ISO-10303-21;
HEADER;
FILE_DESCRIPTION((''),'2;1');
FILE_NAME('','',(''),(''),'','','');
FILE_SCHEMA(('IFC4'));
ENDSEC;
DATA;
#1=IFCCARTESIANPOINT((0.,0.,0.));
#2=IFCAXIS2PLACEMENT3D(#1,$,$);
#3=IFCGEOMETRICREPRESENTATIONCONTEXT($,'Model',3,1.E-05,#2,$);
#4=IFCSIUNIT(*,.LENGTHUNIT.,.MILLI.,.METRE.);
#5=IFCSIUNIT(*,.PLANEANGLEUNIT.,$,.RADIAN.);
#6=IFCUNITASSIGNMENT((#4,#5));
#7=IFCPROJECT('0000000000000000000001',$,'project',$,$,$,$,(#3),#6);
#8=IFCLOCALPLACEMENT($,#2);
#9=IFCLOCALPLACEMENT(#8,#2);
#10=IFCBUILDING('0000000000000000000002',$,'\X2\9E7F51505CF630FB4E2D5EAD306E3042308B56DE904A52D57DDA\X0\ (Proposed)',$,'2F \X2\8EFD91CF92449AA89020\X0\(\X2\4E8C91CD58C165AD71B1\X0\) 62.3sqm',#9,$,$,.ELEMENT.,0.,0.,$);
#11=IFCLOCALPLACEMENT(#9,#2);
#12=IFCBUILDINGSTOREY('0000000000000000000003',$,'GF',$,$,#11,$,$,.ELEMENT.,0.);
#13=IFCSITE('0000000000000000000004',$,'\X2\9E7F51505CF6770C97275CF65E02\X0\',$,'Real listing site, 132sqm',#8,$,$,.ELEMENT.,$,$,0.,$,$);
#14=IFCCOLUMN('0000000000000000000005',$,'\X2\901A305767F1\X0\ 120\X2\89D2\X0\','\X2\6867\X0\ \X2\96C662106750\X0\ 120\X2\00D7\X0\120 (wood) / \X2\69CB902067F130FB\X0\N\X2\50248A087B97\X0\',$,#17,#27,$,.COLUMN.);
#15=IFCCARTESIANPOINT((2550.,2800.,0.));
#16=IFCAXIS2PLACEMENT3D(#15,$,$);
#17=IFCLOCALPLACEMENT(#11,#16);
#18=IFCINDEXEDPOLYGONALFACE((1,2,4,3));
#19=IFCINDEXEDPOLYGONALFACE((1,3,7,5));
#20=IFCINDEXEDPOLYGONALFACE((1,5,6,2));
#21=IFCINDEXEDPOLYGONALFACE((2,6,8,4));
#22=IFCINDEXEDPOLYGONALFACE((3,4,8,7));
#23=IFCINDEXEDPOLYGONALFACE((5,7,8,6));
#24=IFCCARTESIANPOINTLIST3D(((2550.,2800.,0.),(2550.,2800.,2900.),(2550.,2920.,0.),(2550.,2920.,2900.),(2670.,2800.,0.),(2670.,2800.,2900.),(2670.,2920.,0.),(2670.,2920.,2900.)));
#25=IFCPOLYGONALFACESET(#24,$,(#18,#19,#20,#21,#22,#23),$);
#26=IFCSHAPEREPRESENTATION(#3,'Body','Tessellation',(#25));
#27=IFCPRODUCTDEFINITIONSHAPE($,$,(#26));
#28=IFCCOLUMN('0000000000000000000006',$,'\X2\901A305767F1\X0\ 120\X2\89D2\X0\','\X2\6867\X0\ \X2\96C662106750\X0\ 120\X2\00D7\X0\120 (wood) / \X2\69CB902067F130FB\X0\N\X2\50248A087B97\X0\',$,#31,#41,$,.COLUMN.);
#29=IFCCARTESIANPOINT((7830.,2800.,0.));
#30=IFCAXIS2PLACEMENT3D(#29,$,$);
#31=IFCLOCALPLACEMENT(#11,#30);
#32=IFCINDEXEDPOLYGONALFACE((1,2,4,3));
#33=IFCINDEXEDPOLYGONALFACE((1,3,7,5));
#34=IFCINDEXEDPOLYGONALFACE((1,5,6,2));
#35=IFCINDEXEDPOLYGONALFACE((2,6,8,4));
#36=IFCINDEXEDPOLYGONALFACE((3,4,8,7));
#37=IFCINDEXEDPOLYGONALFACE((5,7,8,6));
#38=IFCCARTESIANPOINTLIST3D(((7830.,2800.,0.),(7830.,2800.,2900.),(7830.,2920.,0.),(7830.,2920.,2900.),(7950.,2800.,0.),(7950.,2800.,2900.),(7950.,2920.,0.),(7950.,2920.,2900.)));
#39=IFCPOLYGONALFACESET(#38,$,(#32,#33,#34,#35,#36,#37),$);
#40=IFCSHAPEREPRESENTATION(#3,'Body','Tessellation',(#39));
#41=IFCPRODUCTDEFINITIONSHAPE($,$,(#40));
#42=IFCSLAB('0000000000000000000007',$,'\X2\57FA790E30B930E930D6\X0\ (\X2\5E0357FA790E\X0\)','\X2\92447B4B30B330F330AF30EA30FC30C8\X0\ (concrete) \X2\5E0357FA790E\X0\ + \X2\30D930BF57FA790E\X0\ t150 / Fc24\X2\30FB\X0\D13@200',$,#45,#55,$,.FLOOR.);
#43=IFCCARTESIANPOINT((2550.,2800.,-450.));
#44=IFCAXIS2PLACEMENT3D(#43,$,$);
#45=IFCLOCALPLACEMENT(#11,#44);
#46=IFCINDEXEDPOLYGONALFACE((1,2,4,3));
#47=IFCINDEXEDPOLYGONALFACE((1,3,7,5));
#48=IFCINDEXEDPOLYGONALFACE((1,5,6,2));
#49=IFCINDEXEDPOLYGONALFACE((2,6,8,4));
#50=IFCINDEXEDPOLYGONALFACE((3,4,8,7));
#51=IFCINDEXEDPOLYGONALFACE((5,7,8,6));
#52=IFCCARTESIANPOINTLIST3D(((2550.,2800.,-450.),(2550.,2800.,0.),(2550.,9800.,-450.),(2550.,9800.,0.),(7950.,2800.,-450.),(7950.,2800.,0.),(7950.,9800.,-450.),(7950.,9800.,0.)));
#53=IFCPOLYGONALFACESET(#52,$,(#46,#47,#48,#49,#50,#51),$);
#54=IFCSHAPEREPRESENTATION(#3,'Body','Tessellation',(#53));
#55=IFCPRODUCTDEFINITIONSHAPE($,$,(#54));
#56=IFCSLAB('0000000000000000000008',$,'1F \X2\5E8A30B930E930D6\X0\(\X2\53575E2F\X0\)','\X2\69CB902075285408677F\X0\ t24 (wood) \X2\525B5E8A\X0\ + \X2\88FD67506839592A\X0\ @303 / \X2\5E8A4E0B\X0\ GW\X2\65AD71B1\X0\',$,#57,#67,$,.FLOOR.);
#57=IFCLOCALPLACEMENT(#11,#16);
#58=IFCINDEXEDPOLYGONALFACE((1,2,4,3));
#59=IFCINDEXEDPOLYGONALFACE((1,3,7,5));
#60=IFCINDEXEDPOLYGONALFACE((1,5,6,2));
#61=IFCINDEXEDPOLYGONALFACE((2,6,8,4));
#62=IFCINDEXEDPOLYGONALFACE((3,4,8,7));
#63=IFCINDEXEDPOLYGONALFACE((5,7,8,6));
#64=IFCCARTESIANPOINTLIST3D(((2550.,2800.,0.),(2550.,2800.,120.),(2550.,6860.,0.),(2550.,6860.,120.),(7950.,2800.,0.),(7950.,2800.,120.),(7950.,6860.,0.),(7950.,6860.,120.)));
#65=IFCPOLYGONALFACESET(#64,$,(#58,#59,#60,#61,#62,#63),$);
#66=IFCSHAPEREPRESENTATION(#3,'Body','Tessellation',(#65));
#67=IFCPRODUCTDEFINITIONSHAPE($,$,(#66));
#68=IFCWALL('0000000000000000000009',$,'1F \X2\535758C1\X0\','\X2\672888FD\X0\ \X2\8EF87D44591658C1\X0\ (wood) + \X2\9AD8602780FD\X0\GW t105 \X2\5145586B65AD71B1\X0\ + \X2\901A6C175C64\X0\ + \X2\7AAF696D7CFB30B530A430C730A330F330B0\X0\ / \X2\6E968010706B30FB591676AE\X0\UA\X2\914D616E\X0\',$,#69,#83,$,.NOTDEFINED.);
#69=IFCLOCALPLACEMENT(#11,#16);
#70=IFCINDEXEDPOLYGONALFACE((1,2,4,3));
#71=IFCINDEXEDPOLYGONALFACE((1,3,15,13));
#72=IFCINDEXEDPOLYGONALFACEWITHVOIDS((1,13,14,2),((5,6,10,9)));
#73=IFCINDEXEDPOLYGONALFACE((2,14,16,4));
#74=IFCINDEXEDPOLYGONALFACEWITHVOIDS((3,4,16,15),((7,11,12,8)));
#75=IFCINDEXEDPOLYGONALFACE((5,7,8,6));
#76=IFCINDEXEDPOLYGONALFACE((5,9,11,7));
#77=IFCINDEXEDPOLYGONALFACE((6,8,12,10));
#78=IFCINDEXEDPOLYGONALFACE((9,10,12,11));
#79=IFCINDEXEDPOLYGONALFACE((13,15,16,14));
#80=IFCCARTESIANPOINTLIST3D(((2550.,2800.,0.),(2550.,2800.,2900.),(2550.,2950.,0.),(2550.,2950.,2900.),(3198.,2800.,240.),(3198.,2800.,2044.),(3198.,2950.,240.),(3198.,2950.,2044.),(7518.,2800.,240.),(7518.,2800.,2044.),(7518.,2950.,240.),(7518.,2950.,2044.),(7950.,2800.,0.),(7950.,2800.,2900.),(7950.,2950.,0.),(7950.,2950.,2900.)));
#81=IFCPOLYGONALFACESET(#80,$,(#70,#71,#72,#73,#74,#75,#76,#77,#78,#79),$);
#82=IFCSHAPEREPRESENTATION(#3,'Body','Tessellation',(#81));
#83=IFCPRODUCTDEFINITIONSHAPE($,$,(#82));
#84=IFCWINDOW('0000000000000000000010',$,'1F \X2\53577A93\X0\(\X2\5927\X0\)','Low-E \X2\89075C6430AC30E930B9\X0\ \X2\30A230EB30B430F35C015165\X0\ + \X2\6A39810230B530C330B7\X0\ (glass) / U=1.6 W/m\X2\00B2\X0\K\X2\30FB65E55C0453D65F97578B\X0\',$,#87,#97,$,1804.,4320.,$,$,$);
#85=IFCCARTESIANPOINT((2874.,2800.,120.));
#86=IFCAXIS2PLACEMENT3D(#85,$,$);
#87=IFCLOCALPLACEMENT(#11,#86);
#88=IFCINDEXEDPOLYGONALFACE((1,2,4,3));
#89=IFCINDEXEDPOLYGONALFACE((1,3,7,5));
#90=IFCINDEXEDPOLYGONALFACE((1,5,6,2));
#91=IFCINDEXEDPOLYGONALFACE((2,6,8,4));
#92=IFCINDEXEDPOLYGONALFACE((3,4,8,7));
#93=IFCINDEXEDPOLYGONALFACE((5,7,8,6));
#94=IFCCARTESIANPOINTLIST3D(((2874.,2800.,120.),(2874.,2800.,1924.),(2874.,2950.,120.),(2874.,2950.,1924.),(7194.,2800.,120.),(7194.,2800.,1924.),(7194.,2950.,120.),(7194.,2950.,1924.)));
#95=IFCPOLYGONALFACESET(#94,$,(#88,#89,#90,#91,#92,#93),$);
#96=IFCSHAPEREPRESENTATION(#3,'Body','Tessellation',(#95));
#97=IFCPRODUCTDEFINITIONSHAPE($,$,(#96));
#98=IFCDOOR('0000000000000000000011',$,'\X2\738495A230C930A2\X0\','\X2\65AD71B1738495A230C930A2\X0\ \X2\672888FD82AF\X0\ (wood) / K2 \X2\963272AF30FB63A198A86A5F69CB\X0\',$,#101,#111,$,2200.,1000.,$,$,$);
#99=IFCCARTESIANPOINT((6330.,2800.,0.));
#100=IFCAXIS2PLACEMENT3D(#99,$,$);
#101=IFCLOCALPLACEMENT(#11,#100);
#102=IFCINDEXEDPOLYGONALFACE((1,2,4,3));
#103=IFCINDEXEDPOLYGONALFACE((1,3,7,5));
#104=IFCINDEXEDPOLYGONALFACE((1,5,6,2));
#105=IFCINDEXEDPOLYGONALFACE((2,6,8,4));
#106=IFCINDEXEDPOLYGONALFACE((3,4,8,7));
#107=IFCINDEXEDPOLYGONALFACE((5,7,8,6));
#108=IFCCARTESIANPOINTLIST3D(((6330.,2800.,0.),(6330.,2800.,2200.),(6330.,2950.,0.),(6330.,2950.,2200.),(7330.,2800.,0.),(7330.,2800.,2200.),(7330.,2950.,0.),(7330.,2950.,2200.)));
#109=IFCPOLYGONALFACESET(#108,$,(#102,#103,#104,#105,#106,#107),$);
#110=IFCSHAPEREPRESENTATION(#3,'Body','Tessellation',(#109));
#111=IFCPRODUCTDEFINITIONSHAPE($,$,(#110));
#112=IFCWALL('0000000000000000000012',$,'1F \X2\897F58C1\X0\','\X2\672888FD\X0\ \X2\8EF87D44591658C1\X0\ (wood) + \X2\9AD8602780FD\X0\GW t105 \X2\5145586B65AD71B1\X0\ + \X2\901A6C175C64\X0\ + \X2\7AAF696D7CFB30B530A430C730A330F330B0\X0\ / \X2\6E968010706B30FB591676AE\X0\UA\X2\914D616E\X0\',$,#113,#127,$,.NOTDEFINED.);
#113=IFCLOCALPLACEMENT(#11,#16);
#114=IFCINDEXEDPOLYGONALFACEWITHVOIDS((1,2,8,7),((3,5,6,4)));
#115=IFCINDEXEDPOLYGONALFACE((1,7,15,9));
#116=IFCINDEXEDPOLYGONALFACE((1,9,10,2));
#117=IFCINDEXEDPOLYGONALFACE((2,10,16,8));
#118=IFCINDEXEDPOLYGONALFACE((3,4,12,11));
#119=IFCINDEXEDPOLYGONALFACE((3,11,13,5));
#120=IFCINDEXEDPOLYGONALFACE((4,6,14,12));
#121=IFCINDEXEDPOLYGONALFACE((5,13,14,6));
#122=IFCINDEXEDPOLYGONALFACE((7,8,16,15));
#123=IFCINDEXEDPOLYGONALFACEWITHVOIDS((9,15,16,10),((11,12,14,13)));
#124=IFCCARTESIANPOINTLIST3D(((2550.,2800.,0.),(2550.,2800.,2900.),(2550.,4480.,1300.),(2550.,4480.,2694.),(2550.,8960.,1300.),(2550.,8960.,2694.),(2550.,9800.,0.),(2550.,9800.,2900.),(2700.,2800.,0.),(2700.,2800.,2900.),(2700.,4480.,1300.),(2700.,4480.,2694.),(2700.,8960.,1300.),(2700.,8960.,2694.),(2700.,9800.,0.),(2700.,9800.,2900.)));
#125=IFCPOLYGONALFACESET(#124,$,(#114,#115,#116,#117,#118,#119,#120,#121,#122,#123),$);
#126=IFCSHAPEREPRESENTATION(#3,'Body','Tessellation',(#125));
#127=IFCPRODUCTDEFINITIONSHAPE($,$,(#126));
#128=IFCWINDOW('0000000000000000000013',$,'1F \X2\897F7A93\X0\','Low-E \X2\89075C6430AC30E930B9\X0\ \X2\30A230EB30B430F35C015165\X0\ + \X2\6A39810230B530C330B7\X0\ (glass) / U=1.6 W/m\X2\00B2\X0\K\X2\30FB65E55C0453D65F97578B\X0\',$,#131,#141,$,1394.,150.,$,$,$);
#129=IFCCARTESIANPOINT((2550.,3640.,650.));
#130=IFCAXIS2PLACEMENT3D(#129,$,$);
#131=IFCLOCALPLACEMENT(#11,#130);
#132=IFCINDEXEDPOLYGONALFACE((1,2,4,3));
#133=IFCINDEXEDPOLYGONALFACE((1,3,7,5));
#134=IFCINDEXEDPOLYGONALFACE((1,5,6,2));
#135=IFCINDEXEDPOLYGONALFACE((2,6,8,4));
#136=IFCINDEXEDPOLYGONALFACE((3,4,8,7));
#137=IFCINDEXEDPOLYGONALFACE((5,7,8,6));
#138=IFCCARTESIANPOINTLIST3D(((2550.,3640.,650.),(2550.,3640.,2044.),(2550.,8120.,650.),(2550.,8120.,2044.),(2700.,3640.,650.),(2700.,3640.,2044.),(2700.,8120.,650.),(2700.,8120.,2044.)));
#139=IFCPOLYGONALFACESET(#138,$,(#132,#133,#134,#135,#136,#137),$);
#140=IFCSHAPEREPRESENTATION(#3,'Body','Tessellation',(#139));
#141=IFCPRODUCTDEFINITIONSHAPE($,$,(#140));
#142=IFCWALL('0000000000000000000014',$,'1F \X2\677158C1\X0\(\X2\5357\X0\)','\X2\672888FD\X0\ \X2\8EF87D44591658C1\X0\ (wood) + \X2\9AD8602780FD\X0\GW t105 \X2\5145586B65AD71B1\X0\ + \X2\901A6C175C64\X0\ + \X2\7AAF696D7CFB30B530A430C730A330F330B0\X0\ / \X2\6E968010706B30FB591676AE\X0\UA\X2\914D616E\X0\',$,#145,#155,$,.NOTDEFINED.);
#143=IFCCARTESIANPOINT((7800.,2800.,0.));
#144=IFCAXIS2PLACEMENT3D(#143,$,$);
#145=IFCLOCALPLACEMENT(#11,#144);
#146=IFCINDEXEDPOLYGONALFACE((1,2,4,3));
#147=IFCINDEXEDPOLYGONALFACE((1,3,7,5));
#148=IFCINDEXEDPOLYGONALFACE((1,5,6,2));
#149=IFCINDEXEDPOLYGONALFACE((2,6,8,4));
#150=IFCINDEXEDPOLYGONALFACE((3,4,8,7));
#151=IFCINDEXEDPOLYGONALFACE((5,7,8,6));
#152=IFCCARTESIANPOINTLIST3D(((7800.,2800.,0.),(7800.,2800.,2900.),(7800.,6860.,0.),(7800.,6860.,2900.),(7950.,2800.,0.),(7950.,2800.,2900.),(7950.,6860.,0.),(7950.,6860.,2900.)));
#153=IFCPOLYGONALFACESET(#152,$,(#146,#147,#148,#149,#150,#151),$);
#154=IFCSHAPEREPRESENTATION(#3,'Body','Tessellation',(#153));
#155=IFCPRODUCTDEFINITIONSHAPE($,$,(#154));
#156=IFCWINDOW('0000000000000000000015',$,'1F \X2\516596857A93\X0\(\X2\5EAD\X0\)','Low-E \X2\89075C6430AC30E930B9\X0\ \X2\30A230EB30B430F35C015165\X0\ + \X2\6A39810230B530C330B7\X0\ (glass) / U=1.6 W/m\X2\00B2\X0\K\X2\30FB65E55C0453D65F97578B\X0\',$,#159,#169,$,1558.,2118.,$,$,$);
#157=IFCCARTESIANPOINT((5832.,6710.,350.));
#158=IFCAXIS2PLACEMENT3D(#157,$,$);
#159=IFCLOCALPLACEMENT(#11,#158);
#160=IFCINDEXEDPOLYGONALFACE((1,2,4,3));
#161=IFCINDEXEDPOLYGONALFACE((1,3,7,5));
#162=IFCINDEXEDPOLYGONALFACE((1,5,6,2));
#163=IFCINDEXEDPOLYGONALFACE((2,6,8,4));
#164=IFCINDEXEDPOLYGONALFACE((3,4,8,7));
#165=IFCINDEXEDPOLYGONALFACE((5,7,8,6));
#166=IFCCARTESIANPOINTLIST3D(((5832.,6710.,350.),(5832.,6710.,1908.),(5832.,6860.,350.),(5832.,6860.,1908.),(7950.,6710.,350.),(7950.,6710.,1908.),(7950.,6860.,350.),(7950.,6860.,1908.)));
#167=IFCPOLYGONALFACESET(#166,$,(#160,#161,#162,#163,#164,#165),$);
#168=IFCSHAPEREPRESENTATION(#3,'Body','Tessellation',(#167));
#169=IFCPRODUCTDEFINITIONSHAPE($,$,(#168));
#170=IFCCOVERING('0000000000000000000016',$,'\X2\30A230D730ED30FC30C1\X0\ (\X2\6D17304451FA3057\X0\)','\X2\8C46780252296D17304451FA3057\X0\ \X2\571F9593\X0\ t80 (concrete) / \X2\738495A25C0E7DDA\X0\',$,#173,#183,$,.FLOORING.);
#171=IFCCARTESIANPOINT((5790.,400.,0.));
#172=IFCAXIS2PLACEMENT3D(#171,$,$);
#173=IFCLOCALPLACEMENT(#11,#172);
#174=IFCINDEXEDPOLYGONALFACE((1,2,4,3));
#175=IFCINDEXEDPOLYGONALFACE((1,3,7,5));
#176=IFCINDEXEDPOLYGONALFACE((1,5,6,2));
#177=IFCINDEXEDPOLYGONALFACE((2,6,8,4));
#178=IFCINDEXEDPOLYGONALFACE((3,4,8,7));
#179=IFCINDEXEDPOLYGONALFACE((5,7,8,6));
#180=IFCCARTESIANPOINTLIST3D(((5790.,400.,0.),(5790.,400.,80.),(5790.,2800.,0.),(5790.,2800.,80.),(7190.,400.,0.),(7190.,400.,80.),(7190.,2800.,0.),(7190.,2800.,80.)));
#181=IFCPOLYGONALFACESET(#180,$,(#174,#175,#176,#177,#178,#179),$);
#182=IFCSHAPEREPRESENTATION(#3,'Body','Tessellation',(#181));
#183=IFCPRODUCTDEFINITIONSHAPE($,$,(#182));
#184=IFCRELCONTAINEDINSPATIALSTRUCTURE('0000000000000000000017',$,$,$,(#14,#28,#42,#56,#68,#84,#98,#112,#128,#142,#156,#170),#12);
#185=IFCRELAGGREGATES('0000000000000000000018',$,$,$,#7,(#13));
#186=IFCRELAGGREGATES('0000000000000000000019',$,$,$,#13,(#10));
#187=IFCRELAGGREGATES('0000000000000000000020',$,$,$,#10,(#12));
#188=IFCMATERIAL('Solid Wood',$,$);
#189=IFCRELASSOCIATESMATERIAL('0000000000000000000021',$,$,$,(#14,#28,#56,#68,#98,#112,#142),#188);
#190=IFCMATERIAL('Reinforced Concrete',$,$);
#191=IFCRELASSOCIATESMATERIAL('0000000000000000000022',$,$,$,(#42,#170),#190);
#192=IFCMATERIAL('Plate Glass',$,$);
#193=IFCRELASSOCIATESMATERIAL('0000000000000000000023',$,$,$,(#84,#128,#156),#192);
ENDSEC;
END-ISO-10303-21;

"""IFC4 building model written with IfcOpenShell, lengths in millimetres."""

from ifc_helpers import new_model, si_unit, frame, frame_2d, origin, place, context, project, spatial, rectangle, extrude, material, element, fill, save


model = new_model("IFC4")

# Units and contexts
model_context = context("Model", 3, precision=1e-05, world=origin())
ifc_project = project(units=[si_unit("LENGTHUNIT", "METRE", prefix="MILLI"), si_unit("PLANEANGLEUNIT", "RADIAN")], contexts=[model_context])

# Site, building, storey
site_placement = place(None, origin())
site = spatial("IfcSite", under=ifc_project, at=site_placement, Name="鹿児島県霧島市", ObjectType="Real listing site, 132sqm", CompositionType="ELEMENT", RefElevation=0.0)
building_placement = place(site_placement, origin())
building = spatial("IfcBuilding", under=site, at=building_placement, Name="鹿児島・中庭のある回遊動線 (Proposed)", ObjectType="2F 軽量鉄骨造(二重壁断熱) 62.3sqm", CompositionType="ELEMENT", ElevationOfRefHeight=0.0, ElevationOfTerrain=0.0)
storey_placement = place(building_placement, origin())
storey = spatial("IfcBuildingStorey", under=building, at=storey_placement, Name="GF", CompositionType="ELEMENT", Elevation=0.0)

# Columns
ifc_material_1 = material(Name="Solid Wood")
column_1_placement = place(storey_placement, frame((2550.0, 2800.0, 0.0)))
element("IfcColumn", 1, at=column_1_placement, inside=storey, material=ifc_material_1, Name="通し柱 120角", Description="桧 集成材 120×120 (wood) / 構造柱・N値計算", PredefinedType="COLUMN", context=model_context, shape_type="SweptSolid", body=[
    extrude(rectangle(XDim=120.0, YDim=120.0, at=frame_2d((60.0, 60.0))), frame((2550.0, 2800.0, 0.0)), (0.0, 0.0, 1.0), 2900.0),
])
column_2_placement = place(storey_placement, frame((7830.0, 2800.0, 0.0)))
element("IfcColumn", 2, at=column_2_placement, inside=storey, material=ifc_material_1, Name="通し柱 120角", Description="桧 集成材 120×120 (wood) / 構造柱・N値計算", PredefinedType="COLUMN", context=model_context, shape_type="SweptSolid", body=[
    extrude(rectangle(XDim=120.0, YDim=120.0, at=frame_2d((60.0, 60.0))), frame((7830.0, 2800.0, 0.0)), (0.0, 0.0, 1.0), 2900.0),
])

# Slabs
ifc_material_2 = material(Name="Reinforced Concrete")
slab_1_placement = place(storey_placement, frame((2550.0, 2800.0, -450.0)))
element("IfcSlab", 3, at=slab_1_placement, inside=storey, material=ifc_material_2, Name="基礎スラブ (布基礎)", Description="鉄筋コンクリート (concrete) 布基礎 + ベタ基礎 t150 / Fc24・D13@200", PredefinedType="FLOOR", context=model_context, shape_type="SweptSolid", body=[
    extrude(rectangle(XDim=5400.0, YDim=7000.0, at=frame_2d((2700.0, 3500.0))), frame((2550.0, 2800.0, -450.0)), (0.0, 0.0, 1.0), 450.0),
])
slab_2_placement = place(storey_placement, frame((2550.0, 2800.0, 0.0)))
element("IfcSlab", 4, at=slab_2_placement, inside=storey, material=ifc_material_1, Name="1F 床スラブ(南帯)", Description="構造用合板 t24 (wood) 剛床 + 製材根太 @303 / 床下 GW断熱", PredefinedType="FLOOR", context=model_context, shape_type="SweptSolid", body=[
    extrude(rectangle(XDim=5400.0, YDim=4060.0, at=frame_2d((2700.0, 2030.0))), frame((2550.0, 2800.0, 0.0)), (0.0, 0.0, 1.0), 120.0),
])

# Wall, openings, window, door
wall_1_placement = place(storey_placement, frame((2550.0, 2800.0, 0.0)))
wall_1 = element("IfcWall", 5, at=wall_1_placement, inside=storey, material=ifc_material_1, Name="1F 南壁", Description="木製 軸組外壁 (wood) + 高性能GW t105 充填断熱 + 通気層 + 窯業系サイディング / 準耐火・外皮UA配慮", PredefinedType="NOTDEFINED", context=model_context, shape_type="SweptSolid", body=[
    extrude(rectangle(XDim=5400.0, YDim=150.0, at=frame_2d((2700.0, 75.0))), frame((2550.0, 2800.0, 0.0)), (0.0, 0.0, 1.0), 2900.0),
])
opening_1_placement = place(storey_placement, frame((2874.0, 2800.0, 120.0)))
opening_1 = element("IfcOpeningElement", 6, at=opening_1_placement, cuts=wall_1, PredefinedType="NOTDEFINED", context=model_context, shape_type="SweptSolid", body=[
    extrude(rectangle(XDim=4320.0, YDim=150.0, at=frame_2d((2160.0, 75.0))), frame((2874.0, 2800.0, 120.0)), (0.0, 0.0, 1.0), 1804.0),
])
opening_2_placement = place(storey_placement, frame((6330.0, 2800.0, 0.0)))
opening_2 = element("IfcOpeningElement", 7, at=opening_2_placement, cuts=wall_1, PredefinedType="NOTDEFINED", context=model_context, shape_type="SweptSolid", body=[
    extrude(rectangle(XDim=1000.0, YDim=150.0, at=frame_2d((500.0, 75.0))), frame((6330.0, 2800.0, 0.0)), (0.0, 0.0, 1.0), 2200.0),
])
ifc_material_3 = material(Name="Plate Glass")
window_1_placement = place(storey_placement, frame((2874.0, 2800.0, 120.0)))
window_1 = element("IfcWindow", 8, at=window_1_placement, inside=storey, material=ifc_material_3, Name="1F 南窓(大)", Description="Low-E 複層ガラス アルゴン封入 + 樹脂サッシ (glass) / U=1.6 W/m²K・日射取得型", OverallHeight=1804.0, OverallWidth=4320.0, context=model_context, shape_type="SweptSolid", body=[
    extrude(rectangle(XDim=4320.0, YDim=150.0, at=frame_2d((2160.0, 75.0))), frame((2874.0, 2800.0, 120.0)), (0.0, 0.0, 1.0), 1804.0),
])
fill(opening_1, window_1)
door_1_placement = place(storey_placement, frame((6330.0, 2800.0, 0.0)))
door_1 = element("IfcDoor", 9, at=door_1_placement, inside=storey, material=ifc_material_1, Name="玄関ドア", Description="断熱玄関ドア 木製芯 (wood) / K2 防犯・採風機構", OverallHeight=2200.0, OverallWidth=1000.0, context=model_context, shape_type="SweptSolid", body=[
    extrude(rectangle(XDim=1000.0, YDim=150.0, at=frame_2d((500.0, 75.0))), frame((6330.0, 2800.0, 0.0)), (0.0, 0.0, 1.0), 2200.0),
])
fill(opening_2, door_1)

# Walls, openings, windows
wall_2_placement = place(storey_placement, frame((2550.0, 2800.0, 0.0)))
wall_2 = element("IfcWall", 10, at=wall_2_placement, inside=storey, material=ifc_material_1, Name="1F 西壁", Description="木製 軸組外壁 (wood) + 高性能GW t105 充填断熱 + 通気層 + 窯業系サイディング / 準耐火・外皮UA配慮", PredefinedType="NOTDEFINED", context=model_context, shape_type="SweptSolid", body=[
    extrude(rectangle(XDim=150.0, YDim=7000.0, at=frame_2d((75.0, 3500.0))), frame((2550.0, 2800.0, 0.0)), (0.0, 0.0, 1.0), 2900.0),
])
opening_3_placement = place(storey_placement, frame((2550.0, 3640.0, 650.0)))
opening_3 = element("IfcOpeningElement", 11, at=opening_3_placement, cuts=wall_2, PredefinedType="NOTDEFINED", context=model_context, shape_type="SweptSolid", body=[
    extrude(rectangle(XDim=150.0, YDim=4480.0, at=frame_2d((75.0, 2240.0))), frame((2550.0, 3640.0, 650.0)), (0.0, 0.0, 1.0), 1394.0),
])
window_2_placement = place(storey_placement, frame((2550.0, 3640.0, 650.0)))
window_2 = element("IfcWindow", 12, at=window_2_placement, inside=storey, material=ifc_material_3, Name="1F 西窓", Description="Low-E 複層ガラス アルゴン封入 + 樹脂サッシ (glass) / U=1.6 W/m²K・日射取得型", OverallHeight=1394.0, OverallWidth=150.0, context=model_context, shape_type="SweptSolid", body=[
    extrude(rectangle(XDim=150.0, YDim=4480.0, at=frame_2d((75.0, 2240.0))), frame((2550.0, 3640.0, 650.0)), (0.0, 0.0, 1.0), 1394.0),
])
fill(opening_3, window_2)
wall_3_placement = place(storey_placement, frame((7800.0, 2800.0, 0.0)))
wall_3 = element("IfcWall", 13, at=wall_3_placement, inside=storey, material=ifc_material_1, Name="1F 東壁(南)", Description="木製 軸組外壁 (wood) + 高性能GW t105 充填断熱 + 通気層 + 窯業系サイディング / 準耐火・外皮UA配慮", PredefinedType="NOTDEFINED", context=model_context, shape_type="SweptSolid", body=[
    extrude(rectangle(XDim=150.0, YDim=4060.0, at=frame_2d((75.0, 2030.0))), frame((7800.0, 2800.0, 0.0)), (0.0, 0.0, 1.0), 2900.0),
])
opening_4_placement = place(storey_placement, frame((5832.0, 6710.0, 350.0)))
opening_4 = element("IfcOpeningElement", 14, at=opening_4_placement, cuts=wall_3, PredefinedType="NOTDEFINED", context=model_context, shape_type="SweptSolid", body=[
    extrude(rectangle(XDim=2118.0, YDim=150.0, at=frame_2d((1059.0, 75.0))), frame((5832.0, 6710.0, 350.0)), (0.0, 0.0, 1.0), 1558.0),
])
window_3_placement = place(storey_placement, frame((5832.0, 6710.0, 350.0)))
window_3 = element("IfcWindow", 15, at=window_3_placement, inside=storey, material=ifc_material_3, Name="1F 入隅窓(庭)", Description="Low-E 複層ガラス アルゴン封入 + 樹脂サッシ (glass) / U=1.6 W/m²K・日射取得型", OverallHeight=1558.0, OverallWidth=2118.0, context=model_context, shape_type="SweptSolid", body=[
    extrude(rectangle(XDim=2118.0, YDim=150.0, at=frame_2d((1059.0, 75.0))), frame((5832.0, 6710.0, 350.0)), (0.0, 0.0, 1.0), 1558.0),
])
fill(opening_4, window_3)

# Covering
covering_1_placement = place(storey_placement, frame((5790.0, 400.0, 0.0)))
element("IfcCovering", 16, at=covering_1_placement, inside=storey, material=ifc_material_2, Name="アプローチ (洗い出し)", Description="豆砂利洗い出し 土間 t80 (concrete) / 玄関導線", PredefinedType="FLOORING", context=model_context, shape_type="SweptSolid", body=[
    extrude(rectangle(XDim=1400.0, YDim=2400.0, at=frame_2d((700.0, 1200.0))), frame((5790.0, 400.0, 0.0)), (0.0, 0.0, 1.0), 80.0),
])

save(model, "model.ifc")
